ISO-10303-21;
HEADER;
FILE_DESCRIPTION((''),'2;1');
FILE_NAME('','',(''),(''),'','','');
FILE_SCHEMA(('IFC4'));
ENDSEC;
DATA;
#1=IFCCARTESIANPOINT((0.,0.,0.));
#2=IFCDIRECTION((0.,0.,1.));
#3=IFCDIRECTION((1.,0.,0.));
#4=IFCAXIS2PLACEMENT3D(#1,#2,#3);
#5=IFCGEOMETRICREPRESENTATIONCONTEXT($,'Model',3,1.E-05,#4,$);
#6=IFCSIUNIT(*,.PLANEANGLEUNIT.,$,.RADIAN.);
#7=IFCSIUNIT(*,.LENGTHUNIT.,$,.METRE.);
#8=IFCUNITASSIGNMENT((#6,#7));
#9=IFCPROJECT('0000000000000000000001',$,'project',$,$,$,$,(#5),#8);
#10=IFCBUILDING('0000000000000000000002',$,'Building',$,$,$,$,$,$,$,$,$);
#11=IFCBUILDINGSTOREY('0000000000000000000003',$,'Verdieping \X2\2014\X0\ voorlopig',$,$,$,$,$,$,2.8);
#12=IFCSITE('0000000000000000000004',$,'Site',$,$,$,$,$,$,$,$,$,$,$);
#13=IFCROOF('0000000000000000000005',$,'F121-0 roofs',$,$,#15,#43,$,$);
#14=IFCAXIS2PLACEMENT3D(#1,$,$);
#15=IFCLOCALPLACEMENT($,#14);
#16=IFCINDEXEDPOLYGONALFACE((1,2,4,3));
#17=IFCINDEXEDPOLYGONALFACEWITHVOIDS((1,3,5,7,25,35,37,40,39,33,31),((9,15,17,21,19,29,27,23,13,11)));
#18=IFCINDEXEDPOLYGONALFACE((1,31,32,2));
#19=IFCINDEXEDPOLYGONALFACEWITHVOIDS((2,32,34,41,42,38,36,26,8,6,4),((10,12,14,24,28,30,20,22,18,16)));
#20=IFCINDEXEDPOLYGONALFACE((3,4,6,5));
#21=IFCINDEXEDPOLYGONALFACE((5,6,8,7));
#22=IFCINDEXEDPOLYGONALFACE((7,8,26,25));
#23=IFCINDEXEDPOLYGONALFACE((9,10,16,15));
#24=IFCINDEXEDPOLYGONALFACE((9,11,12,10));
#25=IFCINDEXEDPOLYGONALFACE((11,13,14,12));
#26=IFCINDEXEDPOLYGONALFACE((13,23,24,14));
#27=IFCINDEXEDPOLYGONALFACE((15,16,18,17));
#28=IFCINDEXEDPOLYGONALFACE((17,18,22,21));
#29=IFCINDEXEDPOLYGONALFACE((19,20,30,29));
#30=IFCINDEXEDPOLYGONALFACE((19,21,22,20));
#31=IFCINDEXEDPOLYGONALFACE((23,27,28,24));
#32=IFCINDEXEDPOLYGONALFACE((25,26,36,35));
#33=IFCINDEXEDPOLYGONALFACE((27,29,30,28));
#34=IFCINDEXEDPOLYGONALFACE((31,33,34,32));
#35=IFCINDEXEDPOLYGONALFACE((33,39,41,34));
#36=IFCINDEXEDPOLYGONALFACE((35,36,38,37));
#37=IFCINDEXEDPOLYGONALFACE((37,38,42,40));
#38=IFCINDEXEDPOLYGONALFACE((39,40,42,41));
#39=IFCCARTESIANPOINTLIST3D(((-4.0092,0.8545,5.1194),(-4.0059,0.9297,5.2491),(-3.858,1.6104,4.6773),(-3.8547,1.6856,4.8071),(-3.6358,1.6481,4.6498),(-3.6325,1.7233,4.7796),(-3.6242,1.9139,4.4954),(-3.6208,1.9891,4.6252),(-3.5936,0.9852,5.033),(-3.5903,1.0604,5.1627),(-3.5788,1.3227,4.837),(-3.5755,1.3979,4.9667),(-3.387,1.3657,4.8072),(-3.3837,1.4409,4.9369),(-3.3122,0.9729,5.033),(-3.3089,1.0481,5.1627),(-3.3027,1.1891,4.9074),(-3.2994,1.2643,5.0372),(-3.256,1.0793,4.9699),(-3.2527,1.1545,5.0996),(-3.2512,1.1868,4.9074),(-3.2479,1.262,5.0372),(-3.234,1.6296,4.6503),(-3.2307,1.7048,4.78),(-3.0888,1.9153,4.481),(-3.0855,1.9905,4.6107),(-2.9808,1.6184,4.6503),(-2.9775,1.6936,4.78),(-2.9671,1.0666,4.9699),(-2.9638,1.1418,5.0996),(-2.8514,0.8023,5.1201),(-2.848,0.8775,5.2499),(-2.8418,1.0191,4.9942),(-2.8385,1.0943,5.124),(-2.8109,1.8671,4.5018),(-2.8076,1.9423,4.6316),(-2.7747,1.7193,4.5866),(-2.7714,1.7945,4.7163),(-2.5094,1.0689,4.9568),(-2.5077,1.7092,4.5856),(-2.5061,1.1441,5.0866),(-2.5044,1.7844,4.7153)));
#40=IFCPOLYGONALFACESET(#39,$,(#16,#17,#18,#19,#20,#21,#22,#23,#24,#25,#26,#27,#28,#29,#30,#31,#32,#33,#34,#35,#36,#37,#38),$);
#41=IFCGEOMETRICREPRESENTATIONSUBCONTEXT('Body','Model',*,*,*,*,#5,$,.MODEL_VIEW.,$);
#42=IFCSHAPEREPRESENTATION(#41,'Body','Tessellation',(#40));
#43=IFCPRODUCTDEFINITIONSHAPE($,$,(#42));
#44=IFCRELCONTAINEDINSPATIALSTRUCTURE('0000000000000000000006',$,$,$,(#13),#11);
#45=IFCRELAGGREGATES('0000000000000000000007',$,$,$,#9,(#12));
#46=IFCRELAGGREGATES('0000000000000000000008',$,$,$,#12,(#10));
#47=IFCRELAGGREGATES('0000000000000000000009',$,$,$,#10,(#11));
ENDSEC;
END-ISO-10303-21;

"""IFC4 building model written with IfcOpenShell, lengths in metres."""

from ifc_helpers import new_model, si_unit, frame, origin_with_axes, place, context, subcontext, project, spatial, polyline, outline, extrude, element, save


model = new_model("IFC4")

# Units and contexts
model_context = context("Model", 3, precision=1e-05, world=origin_with_axes())
body_context = subcontext(model_context, "Body", "Model", "MODEL_VIEW")
ifc_project = project(units=[si_unit("PLANEANGLEUNIT", "RADIAN"), si_unit("LENGTHUNIT", "METRE")], contexts=[model_context])

# Site, building, storey
site = spatial("IfcSite", under=ifc_project, Name="Site")
building = spatial("IfcBuilding", under=site, Name="Building")
storey = spatial("IfcBuildingStorey", under=building, Name="Verdieping — voorlopig", Elevation=2.8)

# Roof, opening
roof_1_placement = place(None, frame((-3.1657, 1.3747, 4.9697), z_axis=(-0.022042, -0.501412, -0.864928), x_axis=(0.999035, -0.043917, 0.0)))
roof_1 = element("IfcRoof", 1, at=roof_1_placement, inside=storey, Name="F121-0 roofs", context=body_context, shape_type="SweptSolid", body=[
    extrude(outline(polyline([(0.0531, -0.7153), (0.3329, -0.6737), (0.3755, -0.5049), (0.6427, -0.5068), (0.6691, 0.2328), (0.3393, 0.3073), (0.3392, 0.5582), (-0.8198, 0.5566), (-0.7019, -0.3241), (-0.4816, -0.3789), (-0.4816, -0.6865), (0.0531, -0.7153)])), origin_with_axes(), (0.0, 0.0, 1.0), 0.15),
])
opening_1_placement = place(roof_1_placement, frame((0.0, 0.0, -0.05), z_axis=(0.0, 0.0, 1.0), x_axis=(1.0, 0.0, 0.0)))
element("IfcOpeningElement", 2, at=opening_1_placement, cuts=roof_1, PredefinedType="OPENING", context=body_context, shape_type="SweptSolid", body=[
    extrude(outline(polyline([(-0.0794, -0.3779), (-0.2206, -0.0654), (-0.4104, -0.006), (-0.4104, 0.3846), (-0.1287, 0.3846), (-0.1287, 0.1344), (-0.0771, 0.1344), (-0.0771, 0.2588), (0.212, 0.2588), (0.1741, -0.3779), (-0.0794, -0.3779)])), origin_with_axes(), (0.0, 0.0, 1.0), 0.25),
])

save(model, "model.ifc")
